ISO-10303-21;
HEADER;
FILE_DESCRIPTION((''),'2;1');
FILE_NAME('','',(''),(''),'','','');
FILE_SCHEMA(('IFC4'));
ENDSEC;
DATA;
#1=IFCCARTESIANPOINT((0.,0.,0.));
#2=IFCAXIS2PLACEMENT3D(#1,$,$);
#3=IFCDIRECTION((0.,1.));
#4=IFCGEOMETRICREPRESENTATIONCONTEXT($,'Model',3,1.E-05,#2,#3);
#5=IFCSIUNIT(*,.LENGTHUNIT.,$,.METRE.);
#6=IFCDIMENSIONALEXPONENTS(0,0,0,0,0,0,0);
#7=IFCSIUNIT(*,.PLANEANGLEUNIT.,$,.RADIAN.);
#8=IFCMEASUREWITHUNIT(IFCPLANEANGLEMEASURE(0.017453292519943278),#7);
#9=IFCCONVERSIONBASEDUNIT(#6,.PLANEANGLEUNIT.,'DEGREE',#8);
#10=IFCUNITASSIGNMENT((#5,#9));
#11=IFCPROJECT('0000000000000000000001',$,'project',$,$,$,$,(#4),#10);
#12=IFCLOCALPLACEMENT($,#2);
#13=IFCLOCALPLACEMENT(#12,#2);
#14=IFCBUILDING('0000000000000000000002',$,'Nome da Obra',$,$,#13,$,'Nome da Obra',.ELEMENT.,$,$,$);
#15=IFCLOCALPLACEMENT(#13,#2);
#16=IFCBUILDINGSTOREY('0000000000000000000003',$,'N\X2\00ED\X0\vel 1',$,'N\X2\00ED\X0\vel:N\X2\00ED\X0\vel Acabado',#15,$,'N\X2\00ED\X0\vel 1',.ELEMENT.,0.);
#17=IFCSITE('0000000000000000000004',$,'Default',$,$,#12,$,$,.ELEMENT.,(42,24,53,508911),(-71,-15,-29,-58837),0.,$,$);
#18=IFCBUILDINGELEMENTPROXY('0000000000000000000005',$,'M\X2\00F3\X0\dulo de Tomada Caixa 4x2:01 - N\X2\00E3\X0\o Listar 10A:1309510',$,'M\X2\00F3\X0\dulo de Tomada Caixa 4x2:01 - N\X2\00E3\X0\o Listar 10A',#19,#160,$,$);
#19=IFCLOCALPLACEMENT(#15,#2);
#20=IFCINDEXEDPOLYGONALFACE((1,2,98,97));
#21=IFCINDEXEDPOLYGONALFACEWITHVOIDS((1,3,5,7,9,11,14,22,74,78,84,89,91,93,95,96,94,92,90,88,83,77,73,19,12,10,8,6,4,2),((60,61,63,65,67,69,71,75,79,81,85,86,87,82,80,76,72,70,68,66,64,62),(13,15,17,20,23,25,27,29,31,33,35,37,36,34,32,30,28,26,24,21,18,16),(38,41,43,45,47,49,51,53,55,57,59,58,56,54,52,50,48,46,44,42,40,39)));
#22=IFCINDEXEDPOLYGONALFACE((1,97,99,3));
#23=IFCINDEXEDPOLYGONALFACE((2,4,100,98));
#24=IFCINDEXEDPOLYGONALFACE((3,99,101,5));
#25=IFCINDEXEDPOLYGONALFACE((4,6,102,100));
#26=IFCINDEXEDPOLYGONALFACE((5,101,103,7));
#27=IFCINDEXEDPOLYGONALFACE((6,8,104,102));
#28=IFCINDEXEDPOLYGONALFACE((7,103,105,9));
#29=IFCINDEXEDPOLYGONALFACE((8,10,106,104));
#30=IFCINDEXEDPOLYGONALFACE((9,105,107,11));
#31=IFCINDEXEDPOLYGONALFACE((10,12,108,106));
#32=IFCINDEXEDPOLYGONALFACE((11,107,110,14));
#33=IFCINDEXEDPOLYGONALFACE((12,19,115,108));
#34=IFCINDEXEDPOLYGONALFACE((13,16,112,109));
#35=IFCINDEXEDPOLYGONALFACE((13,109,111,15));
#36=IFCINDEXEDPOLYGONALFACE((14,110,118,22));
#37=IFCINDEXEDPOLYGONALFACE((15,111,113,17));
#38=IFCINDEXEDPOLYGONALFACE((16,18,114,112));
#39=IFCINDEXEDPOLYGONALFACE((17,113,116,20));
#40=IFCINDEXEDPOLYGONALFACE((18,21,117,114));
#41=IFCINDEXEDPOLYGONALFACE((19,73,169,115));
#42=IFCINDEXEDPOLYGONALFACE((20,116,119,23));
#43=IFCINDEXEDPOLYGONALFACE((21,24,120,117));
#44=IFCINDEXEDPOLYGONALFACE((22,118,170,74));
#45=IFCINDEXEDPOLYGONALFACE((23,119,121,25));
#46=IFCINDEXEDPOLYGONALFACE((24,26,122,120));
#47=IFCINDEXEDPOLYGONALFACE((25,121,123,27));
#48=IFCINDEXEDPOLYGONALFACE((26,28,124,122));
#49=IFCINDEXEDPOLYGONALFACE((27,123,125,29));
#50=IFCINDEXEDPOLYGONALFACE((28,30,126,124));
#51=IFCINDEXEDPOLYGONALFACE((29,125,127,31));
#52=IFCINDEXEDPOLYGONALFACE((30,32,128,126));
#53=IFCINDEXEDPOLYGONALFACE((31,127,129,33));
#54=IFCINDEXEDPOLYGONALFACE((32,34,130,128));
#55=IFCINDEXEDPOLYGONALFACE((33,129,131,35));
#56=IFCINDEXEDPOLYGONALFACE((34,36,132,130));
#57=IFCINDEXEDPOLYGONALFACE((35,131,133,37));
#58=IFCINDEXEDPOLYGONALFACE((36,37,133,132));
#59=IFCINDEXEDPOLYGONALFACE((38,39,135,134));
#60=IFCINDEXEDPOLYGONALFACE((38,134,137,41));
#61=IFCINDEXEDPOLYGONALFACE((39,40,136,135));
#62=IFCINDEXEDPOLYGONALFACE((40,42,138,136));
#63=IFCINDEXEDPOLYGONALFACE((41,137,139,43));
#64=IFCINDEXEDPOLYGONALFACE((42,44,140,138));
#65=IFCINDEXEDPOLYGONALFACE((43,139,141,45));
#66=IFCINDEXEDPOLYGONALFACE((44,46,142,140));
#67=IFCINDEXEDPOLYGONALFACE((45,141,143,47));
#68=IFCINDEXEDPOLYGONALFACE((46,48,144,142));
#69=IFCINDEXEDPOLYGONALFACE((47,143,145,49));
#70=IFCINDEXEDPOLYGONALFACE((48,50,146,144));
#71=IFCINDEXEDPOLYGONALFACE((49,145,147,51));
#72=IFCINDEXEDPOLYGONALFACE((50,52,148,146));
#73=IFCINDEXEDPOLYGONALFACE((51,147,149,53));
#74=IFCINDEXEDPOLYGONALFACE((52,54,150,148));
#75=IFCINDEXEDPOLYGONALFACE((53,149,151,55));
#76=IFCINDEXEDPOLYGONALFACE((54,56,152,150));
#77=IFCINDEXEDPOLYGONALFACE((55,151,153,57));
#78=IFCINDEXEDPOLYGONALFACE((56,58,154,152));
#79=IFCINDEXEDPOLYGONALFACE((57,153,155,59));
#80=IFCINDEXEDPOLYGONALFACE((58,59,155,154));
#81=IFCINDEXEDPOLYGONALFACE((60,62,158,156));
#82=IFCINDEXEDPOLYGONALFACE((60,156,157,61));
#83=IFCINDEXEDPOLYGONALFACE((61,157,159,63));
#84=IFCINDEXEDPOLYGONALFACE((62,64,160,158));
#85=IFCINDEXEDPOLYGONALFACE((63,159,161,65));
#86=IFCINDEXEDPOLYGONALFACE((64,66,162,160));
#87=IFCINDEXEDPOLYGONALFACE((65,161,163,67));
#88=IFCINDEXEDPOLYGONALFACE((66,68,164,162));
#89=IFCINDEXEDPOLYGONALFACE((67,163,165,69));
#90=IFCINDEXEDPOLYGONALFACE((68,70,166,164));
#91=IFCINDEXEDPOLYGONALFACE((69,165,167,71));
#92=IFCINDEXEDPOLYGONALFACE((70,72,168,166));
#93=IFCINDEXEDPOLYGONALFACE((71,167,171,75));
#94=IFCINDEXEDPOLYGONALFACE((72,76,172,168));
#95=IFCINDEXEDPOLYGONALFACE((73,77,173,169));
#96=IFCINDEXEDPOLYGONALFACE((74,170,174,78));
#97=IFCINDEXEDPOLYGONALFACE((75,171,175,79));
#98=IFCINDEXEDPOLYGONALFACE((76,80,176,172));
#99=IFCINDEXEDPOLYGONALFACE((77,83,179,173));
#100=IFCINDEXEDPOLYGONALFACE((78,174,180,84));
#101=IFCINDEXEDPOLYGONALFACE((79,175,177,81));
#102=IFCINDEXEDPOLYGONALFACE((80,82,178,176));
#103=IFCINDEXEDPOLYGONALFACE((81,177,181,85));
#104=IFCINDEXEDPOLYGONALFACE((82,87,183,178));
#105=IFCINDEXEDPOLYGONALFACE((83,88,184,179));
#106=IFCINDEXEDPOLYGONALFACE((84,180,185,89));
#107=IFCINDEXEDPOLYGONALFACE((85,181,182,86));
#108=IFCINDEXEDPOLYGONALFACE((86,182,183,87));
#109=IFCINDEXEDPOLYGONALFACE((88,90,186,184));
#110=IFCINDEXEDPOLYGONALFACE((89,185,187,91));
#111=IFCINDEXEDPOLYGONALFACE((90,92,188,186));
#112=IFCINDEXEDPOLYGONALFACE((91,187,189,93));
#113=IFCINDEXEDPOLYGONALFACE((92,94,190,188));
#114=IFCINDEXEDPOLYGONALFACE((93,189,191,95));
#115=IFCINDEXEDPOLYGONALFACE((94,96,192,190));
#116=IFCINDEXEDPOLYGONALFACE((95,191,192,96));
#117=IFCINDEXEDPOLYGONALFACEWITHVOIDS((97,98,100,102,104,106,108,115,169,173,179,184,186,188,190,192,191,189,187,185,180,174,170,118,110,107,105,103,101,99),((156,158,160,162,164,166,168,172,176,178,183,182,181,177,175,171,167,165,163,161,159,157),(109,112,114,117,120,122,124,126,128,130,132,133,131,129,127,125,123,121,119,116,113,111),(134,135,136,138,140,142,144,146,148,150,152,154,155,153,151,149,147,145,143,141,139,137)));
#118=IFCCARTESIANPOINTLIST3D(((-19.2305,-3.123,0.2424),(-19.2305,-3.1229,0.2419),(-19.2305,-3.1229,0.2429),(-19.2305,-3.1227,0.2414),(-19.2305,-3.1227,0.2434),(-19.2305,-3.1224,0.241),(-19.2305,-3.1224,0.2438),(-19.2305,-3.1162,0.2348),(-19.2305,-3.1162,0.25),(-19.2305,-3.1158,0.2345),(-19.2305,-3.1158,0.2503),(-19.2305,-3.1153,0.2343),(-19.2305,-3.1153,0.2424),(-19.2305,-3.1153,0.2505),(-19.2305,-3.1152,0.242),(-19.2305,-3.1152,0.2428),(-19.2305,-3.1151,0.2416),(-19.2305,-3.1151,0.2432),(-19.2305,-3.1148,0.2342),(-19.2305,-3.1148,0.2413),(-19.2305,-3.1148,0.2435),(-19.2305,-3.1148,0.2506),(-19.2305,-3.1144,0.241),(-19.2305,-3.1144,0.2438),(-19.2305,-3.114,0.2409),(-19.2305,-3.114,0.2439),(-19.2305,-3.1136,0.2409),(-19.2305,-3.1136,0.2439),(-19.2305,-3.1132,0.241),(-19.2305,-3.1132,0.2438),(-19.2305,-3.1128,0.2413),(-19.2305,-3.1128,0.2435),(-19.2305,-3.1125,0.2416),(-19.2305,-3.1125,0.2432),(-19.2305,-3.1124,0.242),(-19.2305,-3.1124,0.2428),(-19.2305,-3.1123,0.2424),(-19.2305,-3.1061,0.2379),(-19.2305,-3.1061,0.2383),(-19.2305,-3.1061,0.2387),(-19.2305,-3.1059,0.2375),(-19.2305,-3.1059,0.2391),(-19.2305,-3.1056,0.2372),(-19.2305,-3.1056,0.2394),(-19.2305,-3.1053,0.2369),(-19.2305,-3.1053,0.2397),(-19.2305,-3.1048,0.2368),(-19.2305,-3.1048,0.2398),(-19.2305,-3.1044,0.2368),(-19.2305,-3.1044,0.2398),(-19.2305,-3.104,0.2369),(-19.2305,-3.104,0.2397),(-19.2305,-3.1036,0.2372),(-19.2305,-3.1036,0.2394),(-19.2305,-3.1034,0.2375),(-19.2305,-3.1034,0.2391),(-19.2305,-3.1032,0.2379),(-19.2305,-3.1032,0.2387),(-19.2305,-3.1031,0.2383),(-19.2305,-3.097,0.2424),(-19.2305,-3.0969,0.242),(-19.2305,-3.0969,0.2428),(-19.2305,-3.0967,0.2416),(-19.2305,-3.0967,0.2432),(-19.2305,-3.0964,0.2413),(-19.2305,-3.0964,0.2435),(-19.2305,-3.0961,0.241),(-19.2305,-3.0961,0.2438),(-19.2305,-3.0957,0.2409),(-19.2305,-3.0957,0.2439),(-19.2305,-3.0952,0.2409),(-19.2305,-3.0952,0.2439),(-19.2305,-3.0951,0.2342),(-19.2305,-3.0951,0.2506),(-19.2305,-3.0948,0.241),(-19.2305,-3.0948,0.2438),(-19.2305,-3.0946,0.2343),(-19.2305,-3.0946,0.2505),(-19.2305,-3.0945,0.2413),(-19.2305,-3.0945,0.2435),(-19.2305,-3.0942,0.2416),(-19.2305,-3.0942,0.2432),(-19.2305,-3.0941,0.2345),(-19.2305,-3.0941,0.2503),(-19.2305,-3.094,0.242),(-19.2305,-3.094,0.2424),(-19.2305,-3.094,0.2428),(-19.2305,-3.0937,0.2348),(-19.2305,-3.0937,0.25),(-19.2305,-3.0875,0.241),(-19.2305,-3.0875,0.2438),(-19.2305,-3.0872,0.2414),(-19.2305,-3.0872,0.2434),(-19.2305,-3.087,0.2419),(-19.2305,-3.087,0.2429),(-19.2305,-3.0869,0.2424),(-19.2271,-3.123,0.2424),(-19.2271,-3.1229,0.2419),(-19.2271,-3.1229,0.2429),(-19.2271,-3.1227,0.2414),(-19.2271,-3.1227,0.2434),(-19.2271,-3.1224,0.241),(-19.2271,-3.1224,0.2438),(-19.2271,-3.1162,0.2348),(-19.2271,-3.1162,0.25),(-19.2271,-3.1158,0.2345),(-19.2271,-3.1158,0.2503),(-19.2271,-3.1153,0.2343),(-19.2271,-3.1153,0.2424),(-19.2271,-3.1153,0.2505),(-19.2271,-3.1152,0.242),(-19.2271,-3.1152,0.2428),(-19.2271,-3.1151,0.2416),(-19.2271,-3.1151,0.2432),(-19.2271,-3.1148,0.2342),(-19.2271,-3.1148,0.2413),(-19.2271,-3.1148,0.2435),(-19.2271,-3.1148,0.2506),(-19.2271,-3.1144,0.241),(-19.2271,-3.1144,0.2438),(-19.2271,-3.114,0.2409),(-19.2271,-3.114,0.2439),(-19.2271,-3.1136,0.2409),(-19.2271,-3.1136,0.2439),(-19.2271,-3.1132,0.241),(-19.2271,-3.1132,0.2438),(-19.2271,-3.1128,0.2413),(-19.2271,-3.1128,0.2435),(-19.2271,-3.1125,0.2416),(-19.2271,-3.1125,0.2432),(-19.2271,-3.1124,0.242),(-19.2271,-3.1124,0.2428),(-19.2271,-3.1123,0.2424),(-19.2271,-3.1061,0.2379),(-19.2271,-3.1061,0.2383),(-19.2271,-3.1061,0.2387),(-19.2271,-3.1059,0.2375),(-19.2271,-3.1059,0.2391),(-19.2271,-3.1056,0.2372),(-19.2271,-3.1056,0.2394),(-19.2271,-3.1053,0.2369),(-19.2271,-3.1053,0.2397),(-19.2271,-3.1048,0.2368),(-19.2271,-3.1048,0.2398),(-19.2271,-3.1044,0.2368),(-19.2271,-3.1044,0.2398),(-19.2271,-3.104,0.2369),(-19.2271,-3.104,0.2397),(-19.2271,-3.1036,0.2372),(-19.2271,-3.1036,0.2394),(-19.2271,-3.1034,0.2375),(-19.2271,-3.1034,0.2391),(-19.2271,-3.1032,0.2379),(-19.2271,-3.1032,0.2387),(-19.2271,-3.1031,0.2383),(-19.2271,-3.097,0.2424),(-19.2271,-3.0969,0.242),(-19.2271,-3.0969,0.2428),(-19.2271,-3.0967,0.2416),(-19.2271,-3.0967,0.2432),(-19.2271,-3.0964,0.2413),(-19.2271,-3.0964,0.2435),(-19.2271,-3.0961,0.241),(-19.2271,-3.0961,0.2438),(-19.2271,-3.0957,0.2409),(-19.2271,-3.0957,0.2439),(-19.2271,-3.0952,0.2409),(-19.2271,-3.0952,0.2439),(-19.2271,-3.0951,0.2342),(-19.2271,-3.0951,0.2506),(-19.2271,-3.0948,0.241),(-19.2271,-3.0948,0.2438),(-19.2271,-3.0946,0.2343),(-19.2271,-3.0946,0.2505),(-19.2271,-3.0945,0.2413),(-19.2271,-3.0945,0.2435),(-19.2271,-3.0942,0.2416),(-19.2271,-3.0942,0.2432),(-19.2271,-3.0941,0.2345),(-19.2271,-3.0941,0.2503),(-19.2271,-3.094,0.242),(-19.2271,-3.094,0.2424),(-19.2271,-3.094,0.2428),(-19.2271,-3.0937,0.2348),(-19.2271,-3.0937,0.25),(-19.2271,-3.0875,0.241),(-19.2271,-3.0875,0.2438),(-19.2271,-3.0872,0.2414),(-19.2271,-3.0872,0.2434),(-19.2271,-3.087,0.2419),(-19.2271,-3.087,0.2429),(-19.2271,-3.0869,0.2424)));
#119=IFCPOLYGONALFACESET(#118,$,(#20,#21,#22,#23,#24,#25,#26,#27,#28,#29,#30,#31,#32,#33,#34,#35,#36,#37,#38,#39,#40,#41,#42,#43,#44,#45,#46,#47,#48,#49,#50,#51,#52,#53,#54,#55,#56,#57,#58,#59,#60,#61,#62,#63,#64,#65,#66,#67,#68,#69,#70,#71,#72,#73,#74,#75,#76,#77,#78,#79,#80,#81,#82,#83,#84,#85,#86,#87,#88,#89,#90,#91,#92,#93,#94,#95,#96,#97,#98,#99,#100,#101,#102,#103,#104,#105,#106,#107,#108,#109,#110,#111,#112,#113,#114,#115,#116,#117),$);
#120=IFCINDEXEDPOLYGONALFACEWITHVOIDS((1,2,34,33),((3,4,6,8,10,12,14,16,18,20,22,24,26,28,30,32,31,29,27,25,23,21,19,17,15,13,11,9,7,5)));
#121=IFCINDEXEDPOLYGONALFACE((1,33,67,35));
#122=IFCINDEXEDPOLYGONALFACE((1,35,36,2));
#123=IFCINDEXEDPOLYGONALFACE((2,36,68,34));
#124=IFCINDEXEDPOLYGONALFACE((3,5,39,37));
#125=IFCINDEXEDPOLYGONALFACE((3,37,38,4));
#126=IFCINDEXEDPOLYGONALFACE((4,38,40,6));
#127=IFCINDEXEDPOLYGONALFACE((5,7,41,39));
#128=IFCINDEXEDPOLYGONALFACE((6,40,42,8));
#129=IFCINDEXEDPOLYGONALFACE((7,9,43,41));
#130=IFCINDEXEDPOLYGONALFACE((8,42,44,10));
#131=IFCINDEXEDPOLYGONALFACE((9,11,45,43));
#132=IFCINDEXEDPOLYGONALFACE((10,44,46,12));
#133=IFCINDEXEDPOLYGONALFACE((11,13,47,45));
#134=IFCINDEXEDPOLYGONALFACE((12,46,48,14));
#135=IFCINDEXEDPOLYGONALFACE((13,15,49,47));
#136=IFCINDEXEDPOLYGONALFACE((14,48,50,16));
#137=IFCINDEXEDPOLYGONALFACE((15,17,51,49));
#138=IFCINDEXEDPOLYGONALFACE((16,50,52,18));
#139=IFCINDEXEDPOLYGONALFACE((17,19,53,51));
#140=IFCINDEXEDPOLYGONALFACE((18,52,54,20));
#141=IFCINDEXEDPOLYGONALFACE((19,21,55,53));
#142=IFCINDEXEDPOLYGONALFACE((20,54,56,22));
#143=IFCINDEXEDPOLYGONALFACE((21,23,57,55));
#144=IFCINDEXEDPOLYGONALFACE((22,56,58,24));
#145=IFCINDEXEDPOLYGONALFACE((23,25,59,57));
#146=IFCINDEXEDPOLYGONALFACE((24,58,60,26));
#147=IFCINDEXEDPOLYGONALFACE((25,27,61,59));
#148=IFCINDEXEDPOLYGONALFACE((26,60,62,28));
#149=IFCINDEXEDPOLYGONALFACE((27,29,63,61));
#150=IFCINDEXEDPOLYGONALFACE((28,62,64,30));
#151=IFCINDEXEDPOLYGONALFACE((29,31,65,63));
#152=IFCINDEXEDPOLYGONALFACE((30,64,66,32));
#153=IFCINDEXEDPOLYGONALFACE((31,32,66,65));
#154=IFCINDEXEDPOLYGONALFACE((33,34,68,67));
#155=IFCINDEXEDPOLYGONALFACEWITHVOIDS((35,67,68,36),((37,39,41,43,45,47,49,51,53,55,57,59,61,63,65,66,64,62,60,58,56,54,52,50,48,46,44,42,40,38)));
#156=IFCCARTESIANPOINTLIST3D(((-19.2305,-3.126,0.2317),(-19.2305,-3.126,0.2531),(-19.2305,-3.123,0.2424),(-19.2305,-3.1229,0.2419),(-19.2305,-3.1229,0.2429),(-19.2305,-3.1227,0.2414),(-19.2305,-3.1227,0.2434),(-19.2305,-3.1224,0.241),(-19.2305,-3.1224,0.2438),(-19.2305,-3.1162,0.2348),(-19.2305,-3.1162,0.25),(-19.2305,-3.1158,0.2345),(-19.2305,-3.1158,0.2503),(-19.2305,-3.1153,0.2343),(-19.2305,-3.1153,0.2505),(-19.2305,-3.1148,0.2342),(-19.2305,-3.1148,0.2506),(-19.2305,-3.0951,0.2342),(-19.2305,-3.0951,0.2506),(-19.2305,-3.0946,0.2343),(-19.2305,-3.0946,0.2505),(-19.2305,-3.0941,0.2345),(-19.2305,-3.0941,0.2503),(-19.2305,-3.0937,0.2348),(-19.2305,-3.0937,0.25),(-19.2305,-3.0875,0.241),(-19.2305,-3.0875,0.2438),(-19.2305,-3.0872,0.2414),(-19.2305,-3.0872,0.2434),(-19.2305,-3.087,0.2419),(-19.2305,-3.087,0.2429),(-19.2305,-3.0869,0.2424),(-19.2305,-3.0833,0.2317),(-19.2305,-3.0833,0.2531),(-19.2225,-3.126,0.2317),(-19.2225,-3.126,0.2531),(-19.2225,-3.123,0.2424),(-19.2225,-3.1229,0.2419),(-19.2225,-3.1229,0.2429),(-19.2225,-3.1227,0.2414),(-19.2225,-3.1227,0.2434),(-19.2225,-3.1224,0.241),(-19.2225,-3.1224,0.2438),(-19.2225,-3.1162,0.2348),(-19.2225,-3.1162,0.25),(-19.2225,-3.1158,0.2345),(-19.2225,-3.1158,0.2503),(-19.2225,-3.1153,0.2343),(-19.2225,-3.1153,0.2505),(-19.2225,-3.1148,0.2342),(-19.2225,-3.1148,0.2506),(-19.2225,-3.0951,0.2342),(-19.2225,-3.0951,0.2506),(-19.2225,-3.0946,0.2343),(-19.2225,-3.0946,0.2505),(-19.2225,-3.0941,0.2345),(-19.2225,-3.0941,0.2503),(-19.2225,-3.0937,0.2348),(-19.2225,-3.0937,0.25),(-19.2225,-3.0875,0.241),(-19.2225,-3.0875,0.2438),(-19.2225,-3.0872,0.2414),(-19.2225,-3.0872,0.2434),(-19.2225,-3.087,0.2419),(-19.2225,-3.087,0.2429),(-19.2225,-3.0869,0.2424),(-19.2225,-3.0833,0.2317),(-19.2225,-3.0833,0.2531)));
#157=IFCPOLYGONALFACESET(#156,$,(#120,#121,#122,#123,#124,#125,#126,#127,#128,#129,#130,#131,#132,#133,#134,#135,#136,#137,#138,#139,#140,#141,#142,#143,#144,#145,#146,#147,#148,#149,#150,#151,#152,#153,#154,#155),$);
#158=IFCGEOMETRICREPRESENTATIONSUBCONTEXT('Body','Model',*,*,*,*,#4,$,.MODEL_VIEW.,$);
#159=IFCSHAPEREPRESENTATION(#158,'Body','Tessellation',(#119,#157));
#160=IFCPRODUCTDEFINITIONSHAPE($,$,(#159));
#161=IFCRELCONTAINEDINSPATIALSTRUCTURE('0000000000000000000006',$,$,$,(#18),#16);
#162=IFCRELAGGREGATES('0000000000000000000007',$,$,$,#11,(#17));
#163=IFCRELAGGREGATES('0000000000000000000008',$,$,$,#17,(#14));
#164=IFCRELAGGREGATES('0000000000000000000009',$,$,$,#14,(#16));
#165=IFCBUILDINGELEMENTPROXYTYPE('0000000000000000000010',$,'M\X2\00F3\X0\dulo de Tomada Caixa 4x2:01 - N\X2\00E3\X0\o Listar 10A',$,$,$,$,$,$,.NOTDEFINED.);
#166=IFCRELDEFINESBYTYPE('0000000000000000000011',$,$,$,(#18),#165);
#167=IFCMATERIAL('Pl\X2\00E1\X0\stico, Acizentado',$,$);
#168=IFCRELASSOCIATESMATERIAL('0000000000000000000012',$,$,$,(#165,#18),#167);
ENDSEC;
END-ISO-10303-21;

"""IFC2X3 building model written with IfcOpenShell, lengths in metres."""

from ifc_helpers import new_model, entity, si_unit, converted_unit, direction, frame, frame_2d, origin, place, context, subcontext, project, spatial, polyline, circle_curve, parameter, trimmed, segment, composite_curve, outline, extrude, source, transform, mapped, material, type_object, type_shapes, element, save


model = new_model("IFC2X3")

# Units and contexts
model_context = context("Model", 3, precision=1e-05, world=origin(), true_north=direction((0.0, 1.0)))
body_context = subcontext(model_context, "Body", "Model", "MODEL_VIEW")
ifc_project = project(units=[si_unit("LENGTHUNIT", "METRE"), converted_unit("PLANEANGLEUNIT", "DEGREE", entity("IfcPlaneAngleMeasure", 0.017453292519943278), si_unit("PLANEANGLEUNIT", "RADIAN"), dimensions=[0, 0, 0, 0, 0, 0, 0])], contexts=[model_context])

# Site, building, storey
site_placement = place(None, origin())
site = spatial("IfcSite", under=ifc_project, at=site_placement, Name="Default", CompositionType="ELEMENT", RefLatitude=(42, 24, 53, 508911), RefLongitude=(-71, -15, -29, -58837), RefElevation=0.0)
building_placement = place(site_placement, origin())
building = spatial("IfcBuilding", under=site, at=building_placement, Name="Nome da Obra", LongName="Nome da Obra", CompositionType="ELEMENT")
storey_placement = place(building_placement, origin())
storey = spatial("IfcBuildingStorey", under=building, at=storey_placement, Name="Nível 1", ObjectType="Nível:Nível Acabado", LongName="Nível 1", CompositionType="ELEMENT", Elevation=0.0)

# Building element proxy
ifc_material_1 = material(Name="Plástico, Acizentado")
building_element_proxy_type_1 = type_object("IfcBuildingElementProxyType", Name="Módulo de Tomada Caixa 4x2:01 - Não Listar 10A", PredefinedType="NOTDEFINED", material=ifc_material_1)
shared_shape_1 = source(origin(), body_context, "Body", "SweptSolid", [
    extrude(outline(composite_curve([segment(polyline([(-0.0098, -0.0082), (0.0098, -0.0082)]), True, "CONTINUOUS"), segment(trimmed(circle_curve(frame_2d((0.0098, -0.0062), x_axis=(1.0, 0.0)), 0.002), [parameter(270.0)], [parameter(315.0)], True, "PARAMETER"), True, "CONTINUOUS"), segment(polyline([(0.0112, -0.0076), (0.0174, -0.0014)]), True, "CONTINUOUS"), segment(trimmed(circle_curve(frame_2d((0.016, 0.0), x_axis=(1.0, 0.0)), 0.002), [parameter(315.0)], [parameter(45.0)], True, "PARAMETER"), True, "CONTINUOUS"), segment(polyline([(0.0174, 0.0014), (0.0112, 0.0076)]), True, "CONTINUOUS"), segment(trimmed(circle_curve(frame_2d((0.0098, 0.0062), x_axis=(1.0, 0.0)), 0.002), [parameter(45.0)], [parameter(90.0)], True, "PARAMETER"), True, "CONTINUOUS"), segment(polyline([(0.0098, 0.0082), (-0.0098, 0.0082)]), True, "CONTINUOUS"), segment(trimmed(circle_curve(frame_2d((-0.0098, 0.0062), x_axis=(1.0, 0.0)), 0.002), [parameter(90.0)], [parameter(135.0)], True, "PARAMETER"), True, "CONTINUOUS"), segment(polyline([(-0.0112, 0.0076), (-0.0174, 0.0014)]), True, "CONTINUOUS"), segment(trimmed(circle_curve(frame_2d((-0.016, 0.0), x_axis=(1.0, 0.0)), 0.002), [parameter(135.0)], [parameter(225.0)], True, "PARAMETER"), True, "CONTINUOUS"), segment(polyline([(-0.0174, -0.0014), (-0.0112, -0.0076)]), True, "CONTINUOUS"), segment(trimmed(circle_curve(frame_2d((-0.0098, -0.0062), x_axis=(1.0, 0.0)), 0.002), [parameter(225.0)], [parameter(270.0)], True, "PARAMETER"), True, "CONTINUOUS")], self_intersect=False), holes=[composite_curve([segment(trimmed(circle_curve(frame_2d((0.0089, 0.0), x_axis=(1.0, 0.0)), 0.0015), [parameter(0.0)], [parameter(180.0)], True, "PARAMETER"), False, "CONTINUOUS"), segment(trimmed(circle_curve(frame_2d((0.0089, 0.0), x_axis=(1.0, 0.0)), 0.0015), [parameter(180.0)], [parameter(0.0)], True, "PARAMETER"), False, "CONTINUOUS")], self_intersect=False), composite_curve([segment(trimmed(circle_curve(frame_2d((-0.0003, 0.0041), x_axis=(1.0, 0.0)), 0.0015), [parameter(0.0)], [parameter(180.0)], True, "PARAMETER"), False, "CONTINUOUS"), segment(trimmed(circle_curve(frame_2d((-0.0003, 0.0041), x_axis=(1.0, 0.0)), 0.0015), [parameter(180.0)], [parameter(0.0)], True, "PARAMETER"), False, "CONTINUOUS")], self_intersect=False), composite_curve([segment(trimmed(circle_curve(frame_2d((-0.0095, 0.0), x_axis=(1.0, 0.0)), 0.0015), [parameter(0.0)], [parameter(180.0)], True, "PARAMETER"), False, "CONTINUOUS"), segment(trimmed(circle_curve(frame_2d((-0.0095, 0.0), x_axis=(1.0, 0.0)), 0.0015), [parameter(180.0)], [parameter(0.0)], True, "PARAMETER"), False, "CONTINUOUS")], self_intersect=False)]), frame((0.0003, 0.0, 0.125), z_axis=(0.0, 1.0, 0.0), x_axis=(1.0, 0.0, 0.0)), (0.0, 0.0, 1.0), 0.0034),
    extrude(outline(polyline([(-0.0214, -0.0107), (0.0214, -0.0107), (0.0214, 0.0107), (-0.0214, 0.0107), (-0.0214, -0.0107)]), holes=[composite_curve([segment(polyline([(0.0101, -0.0082), (-0.0095, -0.0082)]), True, "CONTINUOUS"), segment(trimmed(circle_curve(frame_2d((-0.0095, -0.0062), x_axis=(1.0, 0.0)), 0.002), [parameter(225.0)], [parameter(270.0)], True, "PARAMETER"), False, "CONTINUOUS"), segment(polyline([(-0.0109, -0.0076), (-0.0171, -0.0014)]), True, "CONTINUOUS"), segment(trimmed(circle_curve(frame_2d((-0.0157, 0.0), x_axis=(1.0, 0.0)), 0.002), [parameter(135.0)], [parameter(225.0)], True, "PARAMETER"), False, "CONTINUOUS"), segment(polyline([(-0.0171, 0.0014), (-0.0109, 0.0076)]), True, "CONTINUOUS"), segment(trimmed(circle_curve(frame_2d((-0.0095, 0.0062), x_axis=(1.0, 0.0)), 0.002), [parameter(90.0)], [parameter(135.0)], True, "PARAMETER"), False, "CONTINUOUS"), segment(polyline([(-0.0095, 0.0082), (0.0101, 0.0082)]), True, "CONTINUOUS"), segment(trimmed(circle_curve(frame_2d((0.0101, 0.0062), x_axis=(1.0, 0.0)), 0.002), [parameter(45.0)], [parameter(90.0)], True, "PARAMETER"), False, "CONTINUOUS"), segment(polyline([(0.0115, 0.0076), (0.0177, 0.0014)]), True, "CONTINUOUS"), segment(trimmed(circle_curve(frame_2d((0.0163, 0.0), x_axis=(1.0, 0.0)), 0.002), [parameter(315.0)], [parameter(45.0)], True, "PARAMETER"), False, "CONTINUOUS"), segment(polyline([(0.0177, -0.0014), (0.0115, -0.0076)]), True, "CONTINUOUS"), segment(trimmed(circle_curve(frame_2d((0.0101, -0.0062), x_axis=(1.0, 0.0)), 0.002), [parameter(270.0)], [parameter(315.0)], True, "PARAMETER"), False, "CONTINUOUS")], self_intersect=False)]), frame((0.0, 0.0, 0.125), z_axis=(0.0, 1.0, 0.0), x_axis=(1.0, 0.0, 0.0)), (0.0, 0.0, 1.0), 0.008),
])
type_shapes(building_element_proxy_type_1, [shared_shape_1])
for number, where, z_axis, x_axis, name in (
    (1, (-19.2305, -3.1046, 0.1174), (0.0, 0.0, 1.0), (0.0, -1.0, 0.0), "Módulo de Tomada Caixa 4x2:01 - Não Listar 10A:1309510"),
):
    element("IfcBuildingElementProxy", number, at=place(storey_placement, frame(where, z_axis=z_axis, x_axis=x_axis)), inside=storey, type_object=building_element_proxy_type_1, material=ifc_material_1, Name=name, ObjectType="Módulo de Tomada Caixa 4x2:01 - Não Listar 10A", context=body_context, shape_type="MappedRepresentation", body=[
        mapped(shared_shape_1, transform((0.0, 0.0, 0.0), scale=1.0)),
    ])

save(model, "model.ifc")
